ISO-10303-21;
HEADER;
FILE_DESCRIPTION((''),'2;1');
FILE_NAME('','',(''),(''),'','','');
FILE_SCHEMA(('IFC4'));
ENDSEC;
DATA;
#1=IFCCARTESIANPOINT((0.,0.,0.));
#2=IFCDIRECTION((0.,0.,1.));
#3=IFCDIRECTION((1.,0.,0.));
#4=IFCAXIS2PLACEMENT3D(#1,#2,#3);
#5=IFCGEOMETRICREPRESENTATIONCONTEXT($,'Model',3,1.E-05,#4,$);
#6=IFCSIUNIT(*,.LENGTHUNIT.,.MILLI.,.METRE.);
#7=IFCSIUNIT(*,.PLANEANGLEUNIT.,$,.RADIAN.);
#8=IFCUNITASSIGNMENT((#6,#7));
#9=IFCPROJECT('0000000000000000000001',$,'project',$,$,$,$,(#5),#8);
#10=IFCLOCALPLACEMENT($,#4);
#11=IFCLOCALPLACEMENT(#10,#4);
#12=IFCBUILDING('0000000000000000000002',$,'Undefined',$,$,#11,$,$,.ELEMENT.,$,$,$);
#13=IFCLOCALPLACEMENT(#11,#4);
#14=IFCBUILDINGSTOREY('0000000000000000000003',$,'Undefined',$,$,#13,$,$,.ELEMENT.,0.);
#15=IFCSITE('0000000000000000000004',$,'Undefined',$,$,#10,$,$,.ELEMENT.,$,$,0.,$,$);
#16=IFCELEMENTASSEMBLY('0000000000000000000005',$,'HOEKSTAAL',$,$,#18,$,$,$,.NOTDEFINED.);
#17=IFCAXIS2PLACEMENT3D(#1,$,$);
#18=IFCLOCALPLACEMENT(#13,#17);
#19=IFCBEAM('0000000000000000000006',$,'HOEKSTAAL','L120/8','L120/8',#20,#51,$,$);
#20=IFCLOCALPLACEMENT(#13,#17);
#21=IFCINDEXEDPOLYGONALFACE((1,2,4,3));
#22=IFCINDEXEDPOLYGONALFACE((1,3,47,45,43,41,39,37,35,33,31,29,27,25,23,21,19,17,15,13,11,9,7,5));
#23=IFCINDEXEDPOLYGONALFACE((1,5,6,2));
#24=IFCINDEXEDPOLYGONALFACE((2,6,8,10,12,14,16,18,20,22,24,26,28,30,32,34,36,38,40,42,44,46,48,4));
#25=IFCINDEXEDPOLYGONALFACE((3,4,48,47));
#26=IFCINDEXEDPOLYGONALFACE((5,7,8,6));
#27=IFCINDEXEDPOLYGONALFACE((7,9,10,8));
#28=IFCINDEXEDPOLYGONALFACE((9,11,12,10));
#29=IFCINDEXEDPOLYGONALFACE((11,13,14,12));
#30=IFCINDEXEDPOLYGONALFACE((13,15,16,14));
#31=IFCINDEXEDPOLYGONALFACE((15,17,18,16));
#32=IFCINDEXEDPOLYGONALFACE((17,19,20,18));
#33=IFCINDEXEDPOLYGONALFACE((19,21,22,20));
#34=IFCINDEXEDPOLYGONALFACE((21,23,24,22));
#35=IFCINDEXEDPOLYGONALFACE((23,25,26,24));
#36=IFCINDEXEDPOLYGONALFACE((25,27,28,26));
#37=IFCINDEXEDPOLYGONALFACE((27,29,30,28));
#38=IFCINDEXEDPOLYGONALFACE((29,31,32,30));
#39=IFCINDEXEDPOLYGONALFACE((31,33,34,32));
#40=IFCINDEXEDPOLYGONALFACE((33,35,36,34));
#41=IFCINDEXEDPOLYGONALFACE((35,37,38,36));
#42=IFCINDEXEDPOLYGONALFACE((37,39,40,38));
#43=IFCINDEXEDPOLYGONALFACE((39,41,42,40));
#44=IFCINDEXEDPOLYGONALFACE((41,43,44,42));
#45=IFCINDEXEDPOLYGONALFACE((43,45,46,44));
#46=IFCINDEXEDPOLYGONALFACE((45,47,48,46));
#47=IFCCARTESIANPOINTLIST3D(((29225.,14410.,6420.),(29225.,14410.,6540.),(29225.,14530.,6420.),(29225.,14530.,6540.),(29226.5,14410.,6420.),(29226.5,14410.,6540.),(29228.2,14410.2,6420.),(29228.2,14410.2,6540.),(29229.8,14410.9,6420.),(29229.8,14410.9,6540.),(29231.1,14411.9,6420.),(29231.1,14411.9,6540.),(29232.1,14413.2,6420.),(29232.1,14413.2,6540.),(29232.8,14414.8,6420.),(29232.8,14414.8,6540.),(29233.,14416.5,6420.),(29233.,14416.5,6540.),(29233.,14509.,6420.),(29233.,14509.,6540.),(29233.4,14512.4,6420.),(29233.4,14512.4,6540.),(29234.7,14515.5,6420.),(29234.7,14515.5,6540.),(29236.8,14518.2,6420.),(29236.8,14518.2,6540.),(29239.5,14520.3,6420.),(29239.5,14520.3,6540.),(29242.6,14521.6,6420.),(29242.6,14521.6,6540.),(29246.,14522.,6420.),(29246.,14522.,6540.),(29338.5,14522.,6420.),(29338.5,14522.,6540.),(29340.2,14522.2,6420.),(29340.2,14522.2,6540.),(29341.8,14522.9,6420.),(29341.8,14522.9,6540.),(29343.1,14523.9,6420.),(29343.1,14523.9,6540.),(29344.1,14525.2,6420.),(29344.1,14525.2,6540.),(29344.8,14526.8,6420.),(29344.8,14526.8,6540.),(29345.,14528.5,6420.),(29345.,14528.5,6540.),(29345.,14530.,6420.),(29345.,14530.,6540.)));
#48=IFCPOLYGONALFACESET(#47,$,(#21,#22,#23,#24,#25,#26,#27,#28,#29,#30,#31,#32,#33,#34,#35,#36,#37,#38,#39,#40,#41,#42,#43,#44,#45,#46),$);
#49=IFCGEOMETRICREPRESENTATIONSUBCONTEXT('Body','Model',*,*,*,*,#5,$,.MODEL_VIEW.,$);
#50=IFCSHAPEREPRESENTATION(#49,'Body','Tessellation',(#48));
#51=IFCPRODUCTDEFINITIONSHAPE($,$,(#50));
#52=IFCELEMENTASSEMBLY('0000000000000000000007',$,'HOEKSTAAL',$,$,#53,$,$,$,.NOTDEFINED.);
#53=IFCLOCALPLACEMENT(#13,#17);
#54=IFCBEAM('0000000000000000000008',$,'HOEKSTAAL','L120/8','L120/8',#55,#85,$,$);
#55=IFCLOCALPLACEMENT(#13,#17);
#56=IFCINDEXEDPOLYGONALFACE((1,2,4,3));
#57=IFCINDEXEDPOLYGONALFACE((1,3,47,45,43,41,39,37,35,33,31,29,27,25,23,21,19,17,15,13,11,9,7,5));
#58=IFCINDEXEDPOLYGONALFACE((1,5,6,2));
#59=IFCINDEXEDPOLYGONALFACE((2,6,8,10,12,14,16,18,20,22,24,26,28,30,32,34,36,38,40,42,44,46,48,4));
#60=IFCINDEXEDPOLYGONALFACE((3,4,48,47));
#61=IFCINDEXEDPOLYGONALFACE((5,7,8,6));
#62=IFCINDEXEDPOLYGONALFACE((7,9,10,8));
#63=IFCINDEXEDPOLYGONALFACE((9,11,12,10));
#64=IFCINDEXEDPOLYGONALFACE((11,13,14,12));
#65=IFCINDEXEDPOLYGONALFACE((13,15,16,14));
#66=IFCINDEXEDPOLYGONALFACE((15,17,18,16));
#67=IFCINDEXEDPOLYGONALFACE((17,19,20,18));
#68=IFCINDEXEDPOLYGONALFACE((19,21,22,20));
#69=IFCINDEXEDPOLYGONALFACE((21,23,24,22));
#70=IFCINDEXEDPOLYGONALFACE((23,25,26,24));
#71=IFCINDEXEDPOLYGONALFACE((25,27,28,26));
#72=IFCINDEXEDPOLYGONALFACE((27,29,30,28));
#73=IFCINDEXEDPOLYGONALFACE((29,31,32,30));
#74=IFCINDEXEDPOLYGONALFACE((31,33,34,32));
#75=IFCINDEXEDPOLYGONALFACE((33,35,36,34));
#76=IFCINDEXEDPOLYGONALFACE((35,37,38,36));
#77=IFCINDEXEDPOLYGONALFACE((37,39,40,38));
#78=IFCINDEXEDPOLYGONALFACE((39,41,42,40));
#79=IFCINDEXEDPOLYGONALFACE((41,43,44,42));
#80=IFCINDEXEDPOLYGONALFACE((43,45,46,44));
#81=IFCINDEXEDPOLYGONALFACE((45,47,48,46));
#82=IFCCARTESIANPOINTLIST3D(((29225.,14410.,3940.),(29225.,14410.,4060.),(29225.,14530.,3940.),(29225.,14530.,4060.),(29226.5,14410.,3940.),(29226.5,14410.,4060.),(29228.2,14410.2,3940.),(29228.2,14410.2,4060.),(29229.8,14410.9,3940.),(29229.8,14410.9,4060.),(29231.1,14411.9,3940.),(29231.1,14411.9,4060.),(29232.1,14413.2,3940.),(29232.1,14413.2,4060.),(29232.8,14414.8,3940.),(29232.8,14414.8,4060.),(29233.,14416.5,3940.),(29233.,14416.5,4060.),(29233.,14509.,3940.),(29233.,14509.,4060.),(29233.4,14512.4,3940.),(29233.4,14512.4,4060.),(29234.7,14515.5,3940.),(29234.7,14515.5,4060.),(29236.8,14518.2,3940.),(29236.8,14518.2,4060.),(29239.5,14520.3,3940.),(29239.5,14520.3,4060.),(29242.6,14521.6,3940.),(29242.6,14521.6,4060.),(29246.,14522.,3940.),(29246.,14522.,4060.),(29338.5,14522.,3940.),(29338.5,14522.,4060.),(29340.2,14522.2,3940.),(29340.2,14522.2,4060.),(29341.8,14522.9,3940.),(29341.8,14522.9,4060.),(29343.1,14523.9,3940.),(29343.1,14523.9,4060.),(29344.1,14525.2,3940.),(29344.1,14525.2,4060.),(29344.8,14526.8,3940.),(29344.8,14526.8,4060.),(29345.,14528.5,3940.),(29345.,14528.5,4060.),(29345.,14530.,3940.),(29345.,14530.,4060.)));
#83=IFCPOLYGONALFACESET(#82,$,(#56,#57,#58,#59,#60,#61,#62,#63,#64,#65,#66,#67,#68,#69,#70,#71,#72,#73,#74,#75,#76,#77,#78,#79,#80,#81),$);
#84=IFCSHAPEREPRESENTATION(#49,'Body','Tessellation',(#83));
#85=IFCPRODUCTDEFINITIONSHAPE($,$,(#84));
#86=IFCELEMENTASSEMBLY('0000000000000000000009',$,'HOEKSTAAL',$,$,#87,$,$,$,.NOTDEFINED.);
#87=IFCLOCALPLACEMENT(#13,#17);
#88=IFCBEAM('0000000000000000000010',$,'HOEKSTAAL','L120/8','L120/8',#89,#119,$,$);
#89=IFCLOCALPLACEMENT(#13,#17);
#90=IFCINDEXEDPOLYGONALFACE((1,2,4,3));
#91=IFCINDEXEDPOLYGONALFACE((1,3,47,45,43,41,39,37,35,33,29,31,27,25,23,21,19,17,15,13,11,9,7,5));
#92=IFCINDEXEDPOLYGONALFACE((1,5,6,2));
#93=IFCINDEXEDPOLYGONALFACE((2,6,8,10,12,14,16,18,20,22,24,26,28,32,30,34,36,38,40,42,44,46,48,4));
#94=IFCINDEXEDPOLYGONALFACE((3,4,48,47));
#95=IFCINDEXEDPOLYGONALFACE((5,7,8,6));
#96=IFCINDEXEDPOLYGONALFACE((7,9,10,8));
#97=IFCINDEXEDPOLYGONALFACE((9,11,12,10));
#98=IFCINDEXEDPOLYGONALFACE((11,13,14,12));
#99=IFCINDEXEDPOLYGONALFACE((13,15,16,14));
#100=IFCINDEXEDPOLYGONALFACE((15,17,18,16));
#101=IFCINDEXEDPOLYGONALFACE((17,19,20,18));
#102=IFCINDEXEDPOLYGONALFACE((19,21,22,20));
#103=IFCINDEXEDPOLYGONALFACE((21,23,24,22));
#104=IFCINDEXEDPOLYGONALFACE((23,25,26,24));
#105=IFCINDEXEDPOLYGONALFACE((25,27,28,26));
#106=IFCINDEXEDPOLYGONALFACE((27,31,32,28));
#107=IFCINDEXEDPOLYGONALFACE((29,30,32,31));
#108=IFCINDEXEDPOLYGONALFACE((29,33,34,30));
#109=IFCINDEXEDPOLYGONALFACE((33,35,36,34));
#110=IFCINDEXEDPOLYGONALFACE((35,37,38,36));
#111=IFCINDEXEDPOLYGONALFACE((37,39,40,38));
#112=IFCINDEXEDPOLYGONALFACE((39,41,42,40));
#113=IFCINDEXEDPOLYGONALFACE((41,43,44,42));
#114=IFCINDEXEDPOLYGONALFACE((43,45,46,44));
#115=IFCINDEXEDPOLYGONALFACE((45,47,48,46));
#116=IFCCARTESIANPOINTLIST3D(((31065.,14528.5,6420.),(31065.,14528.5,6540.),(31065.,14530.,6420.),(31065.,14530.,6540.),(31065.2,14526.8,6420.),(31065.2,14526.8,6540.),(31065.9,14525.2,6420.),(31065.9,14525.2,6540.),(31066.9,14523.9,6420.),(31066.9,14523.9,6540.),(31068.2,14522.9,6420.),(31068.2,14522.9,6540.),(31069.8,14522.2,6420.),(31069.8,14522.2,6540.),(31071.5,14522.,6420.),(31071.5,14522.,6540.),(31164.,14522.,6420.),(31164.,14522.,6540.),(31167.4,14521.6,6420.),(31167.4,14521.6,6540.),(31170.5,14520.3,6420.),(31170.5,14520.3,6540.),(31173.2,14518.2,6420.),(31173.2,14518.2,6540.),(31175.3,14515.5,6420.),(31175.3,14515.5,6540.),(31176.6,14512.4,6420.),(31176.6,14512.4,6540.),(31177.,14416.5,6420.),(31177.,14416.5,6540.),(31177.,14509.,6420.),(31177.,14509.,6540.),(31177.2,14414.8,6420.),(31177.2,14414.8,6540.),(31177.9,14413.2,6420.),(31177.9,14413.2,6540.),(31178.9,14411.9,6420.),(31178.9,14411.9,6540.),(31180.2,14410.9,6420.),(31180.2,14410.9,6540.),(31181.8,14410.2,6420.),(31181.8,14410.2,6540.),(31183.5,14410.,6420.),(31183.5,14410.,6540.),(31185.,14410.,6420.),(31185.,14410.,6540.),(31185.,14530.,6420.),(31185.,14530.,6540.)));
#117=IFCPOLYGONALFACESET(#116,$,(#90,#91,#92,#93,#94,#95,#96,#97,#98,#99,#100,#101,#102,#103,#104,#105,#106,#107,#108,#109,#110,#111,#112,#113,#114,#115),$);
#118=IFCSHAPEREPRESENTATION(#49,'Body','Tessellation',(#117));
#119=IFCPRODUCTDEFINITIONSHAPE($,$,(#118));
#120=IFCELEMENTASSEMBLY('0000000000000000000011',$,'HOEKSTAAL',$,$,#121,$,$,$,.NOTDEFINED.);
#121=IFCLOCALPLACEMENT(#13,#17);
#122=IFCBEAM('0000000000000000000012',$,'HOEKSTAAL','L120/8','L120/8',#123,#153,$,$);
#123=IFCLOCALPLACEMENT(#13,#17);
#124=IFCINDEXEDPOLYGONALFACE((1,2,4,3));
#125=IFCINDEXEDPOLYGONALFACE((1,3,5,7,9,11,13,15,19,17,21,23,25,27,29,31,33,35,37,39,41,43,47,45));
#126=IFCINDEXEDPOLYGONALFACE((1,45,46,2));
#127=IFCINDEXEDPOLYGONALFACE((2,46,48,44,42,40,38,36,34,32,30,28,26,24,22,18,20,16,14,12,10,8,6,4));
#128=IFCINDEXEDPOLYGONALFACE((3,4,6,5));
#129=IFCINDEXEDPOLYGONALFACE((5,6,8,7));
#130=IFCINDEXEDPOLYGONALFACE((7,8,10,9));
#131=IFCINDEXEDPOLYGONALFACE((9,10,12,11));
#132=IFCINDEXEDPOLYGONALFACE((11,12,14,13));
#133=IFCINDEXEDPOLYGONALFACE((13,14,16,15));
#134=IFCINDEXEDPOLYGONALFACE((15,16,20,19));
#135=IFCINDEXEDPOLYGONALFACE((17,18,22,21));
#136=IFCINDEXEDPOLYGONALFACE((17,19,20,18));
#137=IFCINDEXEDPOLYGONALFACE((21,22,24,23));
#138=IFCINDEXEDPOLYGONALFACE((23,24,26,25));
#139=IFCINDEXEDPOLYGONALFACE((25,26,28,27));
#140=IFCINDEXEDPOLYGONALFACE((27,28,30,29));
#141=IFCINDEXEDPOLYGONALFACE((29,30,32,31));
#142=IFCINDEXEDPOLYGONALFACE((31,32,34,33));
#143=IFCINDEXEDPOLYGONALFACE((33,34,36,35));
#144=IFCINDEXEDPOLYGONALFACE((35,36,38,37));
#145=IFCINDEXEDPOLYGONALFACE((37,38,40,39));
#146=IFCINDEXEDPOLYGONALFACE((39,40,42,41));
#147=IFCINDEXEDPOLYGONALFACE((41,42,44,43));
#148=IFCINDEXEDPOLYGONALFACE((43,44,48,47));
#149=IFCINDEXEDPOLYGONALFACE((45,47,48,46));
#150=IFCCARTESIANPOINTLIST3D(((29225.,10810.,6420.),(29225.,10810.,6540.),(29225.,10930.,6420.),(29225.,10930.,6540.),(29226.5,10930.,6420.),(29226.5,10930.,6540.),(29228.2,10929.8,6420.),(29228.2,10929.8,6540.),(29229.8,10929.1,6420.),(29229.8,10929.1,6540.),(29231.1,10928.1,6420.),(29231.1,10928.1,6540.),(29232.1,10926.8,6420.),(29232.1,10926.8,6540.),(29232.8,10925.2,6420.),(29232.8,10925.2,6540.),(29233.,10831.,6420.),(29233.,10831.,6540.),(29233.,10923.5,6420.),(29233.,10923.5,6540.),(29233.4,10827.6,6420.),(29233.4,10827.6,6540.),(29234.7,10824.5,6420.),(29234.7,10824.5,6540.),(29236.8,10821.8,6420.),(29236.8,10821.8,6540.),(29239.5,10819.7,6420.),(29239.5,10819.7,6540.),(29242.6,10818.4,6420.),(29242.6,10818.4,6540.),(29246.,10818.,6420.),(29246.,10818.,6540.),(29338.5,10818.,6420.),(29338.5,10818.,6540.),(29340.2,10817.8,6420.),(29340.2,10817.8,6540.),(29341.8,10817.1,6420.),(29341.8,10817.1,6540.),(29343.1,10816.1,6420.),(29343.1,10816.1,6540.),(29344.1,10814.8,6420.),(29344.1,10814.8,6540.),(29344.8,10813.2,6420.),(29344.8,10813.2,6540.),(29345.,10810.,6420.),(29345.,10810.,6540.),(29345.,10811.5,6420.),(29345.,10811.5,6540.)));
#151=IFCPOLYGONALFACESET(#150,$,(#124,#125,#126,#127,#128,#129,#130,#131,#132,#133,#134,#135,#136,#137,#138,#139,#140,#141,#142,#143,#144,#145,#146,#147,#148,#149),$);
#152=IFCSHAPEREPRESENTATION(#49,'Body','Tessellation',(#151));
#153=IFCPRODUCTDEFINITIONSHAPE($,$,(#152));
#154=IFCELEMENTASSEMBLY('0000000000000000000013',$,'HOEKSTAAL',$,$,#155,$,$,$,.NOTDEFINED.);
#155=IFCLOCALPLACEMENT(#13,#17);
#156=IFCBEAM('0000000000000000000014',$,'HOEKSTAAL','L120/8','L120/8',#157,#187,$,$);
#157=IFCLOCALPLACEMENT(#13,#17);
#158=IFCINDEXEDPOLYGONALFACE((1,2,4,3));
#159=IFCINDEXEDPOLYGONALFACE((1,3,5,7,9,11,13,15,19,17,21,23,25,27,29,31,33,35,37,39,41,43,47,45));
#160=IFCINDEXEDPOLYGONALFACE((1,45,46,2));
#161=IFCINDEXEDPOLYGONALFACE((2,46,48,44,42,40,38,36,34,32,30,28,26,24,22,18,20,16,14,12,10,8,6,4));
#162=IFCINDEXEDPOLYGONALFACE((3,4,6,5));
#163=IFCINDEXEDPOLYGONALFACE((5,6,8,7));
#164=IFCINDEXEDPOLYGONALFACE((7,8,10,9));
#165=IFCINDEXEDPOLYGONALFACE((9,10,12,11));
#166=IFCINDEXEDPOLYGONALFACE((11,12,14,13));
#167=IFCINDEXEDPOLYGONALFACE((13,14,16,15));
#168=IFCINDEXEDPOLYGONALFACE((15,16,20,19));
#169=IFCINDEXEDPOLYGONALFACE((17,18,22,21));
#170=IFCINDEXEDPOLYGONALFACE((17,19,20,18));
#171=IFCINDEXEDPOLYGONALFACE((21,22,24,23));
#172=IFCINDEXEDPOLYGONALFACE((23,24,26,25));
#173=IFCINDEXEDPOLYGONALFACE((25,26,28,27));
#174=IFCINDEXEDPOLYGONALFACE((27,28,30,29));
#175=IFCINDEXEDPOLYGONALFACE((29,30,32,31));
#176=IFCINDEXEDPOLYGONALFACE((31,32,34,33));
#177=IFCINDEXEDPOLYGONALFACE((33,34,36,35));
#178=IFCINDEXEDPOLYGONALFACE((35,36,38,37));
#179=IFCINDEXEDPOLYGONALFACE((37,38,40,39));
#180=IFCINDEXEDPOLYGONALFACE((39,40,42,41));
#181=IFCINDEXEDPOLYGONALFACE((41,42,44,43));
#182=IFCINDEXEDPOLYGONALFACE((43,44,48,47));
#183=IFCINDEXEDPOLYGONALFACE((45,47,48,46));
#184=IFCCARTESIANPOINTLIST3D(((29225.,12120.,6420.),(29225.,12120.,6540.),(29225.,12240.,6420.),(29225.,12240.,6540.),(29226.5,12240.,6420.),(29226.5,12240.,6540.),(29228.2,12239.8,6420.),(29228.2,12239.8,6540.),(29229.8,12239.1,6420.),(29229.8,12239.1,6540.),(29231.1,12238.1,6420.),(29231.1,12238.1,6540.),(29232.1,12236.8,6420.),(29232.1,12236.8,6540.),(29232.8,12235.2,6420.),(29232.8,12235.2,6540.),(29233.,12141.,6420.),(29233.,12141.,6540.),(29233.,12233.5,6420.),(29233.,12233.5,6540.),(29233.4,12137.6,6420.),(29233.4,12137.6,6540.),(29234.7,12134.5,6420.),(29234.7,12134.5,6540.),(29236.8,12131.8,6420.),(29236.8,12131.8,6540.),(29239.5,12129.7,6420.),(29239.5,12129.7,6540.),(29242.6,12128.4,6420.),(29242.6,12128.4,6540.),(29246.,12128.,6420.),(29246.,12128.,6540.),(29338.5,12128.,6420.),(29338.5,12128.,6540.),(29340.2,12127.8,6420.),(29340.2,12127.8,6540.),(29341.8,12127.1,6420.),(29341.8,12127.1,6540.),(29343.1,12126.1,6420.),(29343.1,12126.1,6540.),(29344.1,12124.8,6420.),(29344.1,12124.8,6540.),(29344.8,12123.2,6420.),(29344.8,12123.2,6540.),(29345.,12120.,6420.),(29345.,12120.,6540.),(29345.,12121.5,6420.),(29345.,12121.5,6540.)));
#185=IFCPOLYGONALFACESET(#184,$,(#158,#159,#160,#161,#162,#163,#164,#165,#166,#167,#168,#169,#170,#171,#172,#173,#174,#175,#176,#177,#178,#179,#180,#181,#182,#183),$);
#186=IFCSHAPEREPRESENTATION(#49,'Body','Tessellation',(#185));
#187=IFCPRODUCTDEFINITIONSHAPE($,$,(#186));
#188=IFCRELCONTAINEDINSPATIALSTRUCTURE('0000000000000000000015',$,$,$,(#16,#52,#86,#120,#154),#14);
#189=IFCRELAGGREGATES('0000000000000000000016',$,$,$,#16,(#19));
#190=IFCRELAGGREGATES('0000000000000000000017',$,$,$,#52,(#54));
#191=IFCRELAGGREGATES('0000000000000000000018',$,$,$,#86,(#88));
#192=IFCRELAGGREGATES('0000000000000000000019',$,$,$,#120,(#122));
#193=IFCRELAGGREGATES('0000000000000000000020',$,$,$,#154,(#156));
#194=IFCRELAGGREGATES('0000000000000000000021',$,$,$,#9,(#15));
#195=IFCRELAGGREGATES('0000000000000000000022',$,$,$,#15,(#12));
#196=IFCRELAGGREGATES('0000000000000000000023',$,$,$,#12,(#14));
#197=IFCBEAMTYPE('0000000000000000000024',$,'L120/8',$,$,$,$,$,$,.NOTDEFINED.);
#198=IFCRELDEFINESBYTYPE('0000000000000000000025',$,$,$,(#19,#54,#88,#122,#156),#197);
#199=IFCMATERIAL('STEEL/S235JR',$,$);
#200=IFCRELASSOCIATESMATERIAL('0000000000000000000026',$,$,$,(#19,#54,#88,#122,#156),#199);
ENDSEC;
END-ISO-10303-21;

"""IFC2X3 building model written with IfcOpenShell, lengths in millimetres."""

from ifc_helpers import new_model, si_unit, frame, origin_with_axes, origin_2d_with_axis, place, context, subcontext, project, spatial, l_section, extrude, material, type_object, element, aggregate, save


model = new_model("IFC2X3")

# Units and contexts
model_context = context("Model", 3, precision=1e-05, world=origin_with_axes())
body_context = subcontext(model_context, "Body", "Model", "MODEL_VIEW")
ifc_project = project(units=[si_unit("LENGTHUNIT", "METRE", prefix="MILLI"), si_unit("PLANEANGLEUNIT", "RADIAN")], contexts=[model_context])

# Site, building, storey
site_placement = place(None, origin_with_axes())
site = spatial("IfcSite", under=ifc_project, at=site_placement, Name="Undefined", CompositionType="ELEMENT", RefElevation=0.0)
building_placement = place(site_placement, origin_with_axes())
building = spatial("IfcBuilding", under=site, at=building_placement, Name="Undefined", CompositionType="ELEMENT")
storey_placement = place(building_placement, origin_with_axes())
storey = spatial("IfcBuildingStorey", under=building, at=storey_placement, Name="Undefined", CompositionType="ELEMENT", Elevation=0.0)

# Element assemblies, beams
assembly_1_placement = place(storey_placement, origin_with_axes())
assembly_1 = element("IfcElementAssembly", 1, at=assembly_1_placement, inside=storey, Name="HOEKSTAAL", PredefinedType="NOTDEFINED")
ifc_material_1 = material(Name="STEEL/S235JR")
beam_type_1 = type_object("IfcBeamType", Name="L120/8", PredefinedType="NOTDEFINED")
beam_1_placement = place(assembly_1_placement, frame((29285.0, 14470.0, 6540.0), z_axis=(1.0, 0.0, 0.0), x_axis=(0.0, 0.0, -1.0)))
beam_1 = element("IfcBeam", 2, at=beam_1_placement, type_object=beam_type_1, material=ifc_material_1, Name="HOEKSTAAL", Description="L120/8", ObjectType="L120/8", context=body_context, shape_type="SweptSolid", body=[
    extrude(l_section(Depth=120.0, Width=120.0, Thickness=8.0, FilletRadius=13.0, EdgeRadius=6.5, at=origin_2d_with_axis()), frame((120.0, 0.0, 0.0), z_axis=(-1.0, 0.0, 0.0), x_axis=(0.0, -1.0, 0.0)), (0.0, 0.0, 1.0), 120.0),
])
aggregate(assembly_1, [beam_1])
assembly_2_placement = place(storey_placement, origin_with_axes())
assembly_2 = element("IfcElementAssembly", 3, at=assembly_2_placement, inside=storey, Name="HOEKSTAAL", PredefinedType="NOTDEFINED")
beam_2_placement = place(assembly_2_placement, frame((29285.0, 14470.0, 4060.0), z_axis=(1.0, 0.0, 0.0), x_axis=(0.0, 0.0, -1.0)))
beam_2 = element("IfcBeam", 4, at=beam_2_placement, type_object=beam_type_1, material=ifc_material_1, Name="HOEKSTAAL", Description="L120/8", ObjectType="L120/8", context=body_context, shape_type="SweptSolid", body=[
    extrude(l_section(Depth=120.0, Width=120.0, Thickness=8.0, FilletRadius=13.0, EdgeRadius=6.5, at=origin_2d_with_axis()), frame((120.0, 0.0, 0.0), z_axis=(-1.0, 0.0, 0.0), x_axis=(0.0, -1.0, 0.0)), (0.0, 0.0, 1.0), 120.0),
])
aggregate(assembly_2, [beam_2])
assembly_3_placement = place(storey_placement, origin_with_axes())
assembly_3 = element("IfcElementAssembly", 5, at=assembly_3_placement, inside=storey, Name="HOEKSTAAL", PredefinedType="NOTDEFINED")
beam_3_placement = place(assembly_3_placement, frame((31125.0, 14470.0, 6420.0), z_axis=(-1.0, 0.0, 0.0), x_axis=(0.0, 0.0, 1.0)))
beam_3 = element("IfcBeam", 6, at=beam_3_placement, type_object=beam_type_1, material=ifc_material_1, Name="HOEKSTAAL", Description="L120/8", ObjectType="L120/8", context=body_context, shape_type="SweptSolid", body=[
    extrude(l_section(Depth=120.0, Width=120.0, Thickness=8.0, FilletRadius=13.0, EdgeRadius=6.5, at=origin_2d_with_axis()), frame((120.0, 0.0, 0.0), z_axis=(-1.0, 0.0, 0.0), x_axis=(0.0, -1.0, 0.0)), (0.0, 0.0, 1.0), 120.0),
])
aggregate(assembly_3, [beam_3])
assembly_4_placement = place(storey_placement, origin_with_axes())
assembly_4 = element("IfcElementAssembly", 7, at=assembly_4_placement, inside=storey, Name="HOEKSTAAL", PredefinedType="NOTDEFINED")
beam_4_placement = place(assembly_4_placement, frame((29285.0, 10870.0, 6420.0), z_axis=(1.0, 0.0, 0.0), x_axis=(0.0, 0.0, 1.0)))
beam_4 = element("IfcBeam", 8, at=beam_4_placement, type_object=beam_type_1, material=ifc_material_1, Name="HOEKSTAAL", Description="L120/8", ObjectType="L120/8", context=body_context, shape_type="SweptSolid", body=[
    extrude(l_section(Depth=120.0, Width=120.0, Thickness=8.0, FilletRadius=13.0, EdgeRadius=6.5, at=origin_2d_with_axis()), frame((120.0, 0.0, 0.0), z_axis=(-1.0, 0.0, 0.0), x_axis=(0.0, -1.0, 0.0)), (0.0, 0.0, 1.0), 120.0),
])
aggregate(assembly_4, [beam_4])
assembly_5_placement = place(storey_placement, origin_with_axes())
assembly_5 = element("IfcElementAssembly", 9, at=assembly_5_placement, inside=storey, Name="HOEKSTAAL", PredefinedType="NOTDEFINED")
beam_5_placement = place(assembly_5_placement, frame((29285.0, 12180.0, 6420.0), z_axis=(1.0, 0.0, 0.0), x_axis=(0.0, 0.0, 1.0)))
beam_5 = element("IfcBeam", 10, at=beam_5_placement, type_object=beam_type_1, material=ifc_material_1, Name="HOEKSTAAL", Description="L120/8", ObjectType="L120/8", context=body_context, shape_type="SweptSolid", body=[
    extrude(l_section(Depth=120.0, Width=120.0, Thickness=8.0, FilletRadius=13.0, EdgeRadius=6.5, at=origin_2d_with_axis()), frame((120.0, 0.0, 0.0), z_axis=(-1.0, 0.0, 0.0), x_axis=(0.0, -1.0, 0.0)), (0.0, 0.0, 1.0), 120.0),
])
aggregate(assembly_5, [beam_5])

save(model, "model.ifc")
